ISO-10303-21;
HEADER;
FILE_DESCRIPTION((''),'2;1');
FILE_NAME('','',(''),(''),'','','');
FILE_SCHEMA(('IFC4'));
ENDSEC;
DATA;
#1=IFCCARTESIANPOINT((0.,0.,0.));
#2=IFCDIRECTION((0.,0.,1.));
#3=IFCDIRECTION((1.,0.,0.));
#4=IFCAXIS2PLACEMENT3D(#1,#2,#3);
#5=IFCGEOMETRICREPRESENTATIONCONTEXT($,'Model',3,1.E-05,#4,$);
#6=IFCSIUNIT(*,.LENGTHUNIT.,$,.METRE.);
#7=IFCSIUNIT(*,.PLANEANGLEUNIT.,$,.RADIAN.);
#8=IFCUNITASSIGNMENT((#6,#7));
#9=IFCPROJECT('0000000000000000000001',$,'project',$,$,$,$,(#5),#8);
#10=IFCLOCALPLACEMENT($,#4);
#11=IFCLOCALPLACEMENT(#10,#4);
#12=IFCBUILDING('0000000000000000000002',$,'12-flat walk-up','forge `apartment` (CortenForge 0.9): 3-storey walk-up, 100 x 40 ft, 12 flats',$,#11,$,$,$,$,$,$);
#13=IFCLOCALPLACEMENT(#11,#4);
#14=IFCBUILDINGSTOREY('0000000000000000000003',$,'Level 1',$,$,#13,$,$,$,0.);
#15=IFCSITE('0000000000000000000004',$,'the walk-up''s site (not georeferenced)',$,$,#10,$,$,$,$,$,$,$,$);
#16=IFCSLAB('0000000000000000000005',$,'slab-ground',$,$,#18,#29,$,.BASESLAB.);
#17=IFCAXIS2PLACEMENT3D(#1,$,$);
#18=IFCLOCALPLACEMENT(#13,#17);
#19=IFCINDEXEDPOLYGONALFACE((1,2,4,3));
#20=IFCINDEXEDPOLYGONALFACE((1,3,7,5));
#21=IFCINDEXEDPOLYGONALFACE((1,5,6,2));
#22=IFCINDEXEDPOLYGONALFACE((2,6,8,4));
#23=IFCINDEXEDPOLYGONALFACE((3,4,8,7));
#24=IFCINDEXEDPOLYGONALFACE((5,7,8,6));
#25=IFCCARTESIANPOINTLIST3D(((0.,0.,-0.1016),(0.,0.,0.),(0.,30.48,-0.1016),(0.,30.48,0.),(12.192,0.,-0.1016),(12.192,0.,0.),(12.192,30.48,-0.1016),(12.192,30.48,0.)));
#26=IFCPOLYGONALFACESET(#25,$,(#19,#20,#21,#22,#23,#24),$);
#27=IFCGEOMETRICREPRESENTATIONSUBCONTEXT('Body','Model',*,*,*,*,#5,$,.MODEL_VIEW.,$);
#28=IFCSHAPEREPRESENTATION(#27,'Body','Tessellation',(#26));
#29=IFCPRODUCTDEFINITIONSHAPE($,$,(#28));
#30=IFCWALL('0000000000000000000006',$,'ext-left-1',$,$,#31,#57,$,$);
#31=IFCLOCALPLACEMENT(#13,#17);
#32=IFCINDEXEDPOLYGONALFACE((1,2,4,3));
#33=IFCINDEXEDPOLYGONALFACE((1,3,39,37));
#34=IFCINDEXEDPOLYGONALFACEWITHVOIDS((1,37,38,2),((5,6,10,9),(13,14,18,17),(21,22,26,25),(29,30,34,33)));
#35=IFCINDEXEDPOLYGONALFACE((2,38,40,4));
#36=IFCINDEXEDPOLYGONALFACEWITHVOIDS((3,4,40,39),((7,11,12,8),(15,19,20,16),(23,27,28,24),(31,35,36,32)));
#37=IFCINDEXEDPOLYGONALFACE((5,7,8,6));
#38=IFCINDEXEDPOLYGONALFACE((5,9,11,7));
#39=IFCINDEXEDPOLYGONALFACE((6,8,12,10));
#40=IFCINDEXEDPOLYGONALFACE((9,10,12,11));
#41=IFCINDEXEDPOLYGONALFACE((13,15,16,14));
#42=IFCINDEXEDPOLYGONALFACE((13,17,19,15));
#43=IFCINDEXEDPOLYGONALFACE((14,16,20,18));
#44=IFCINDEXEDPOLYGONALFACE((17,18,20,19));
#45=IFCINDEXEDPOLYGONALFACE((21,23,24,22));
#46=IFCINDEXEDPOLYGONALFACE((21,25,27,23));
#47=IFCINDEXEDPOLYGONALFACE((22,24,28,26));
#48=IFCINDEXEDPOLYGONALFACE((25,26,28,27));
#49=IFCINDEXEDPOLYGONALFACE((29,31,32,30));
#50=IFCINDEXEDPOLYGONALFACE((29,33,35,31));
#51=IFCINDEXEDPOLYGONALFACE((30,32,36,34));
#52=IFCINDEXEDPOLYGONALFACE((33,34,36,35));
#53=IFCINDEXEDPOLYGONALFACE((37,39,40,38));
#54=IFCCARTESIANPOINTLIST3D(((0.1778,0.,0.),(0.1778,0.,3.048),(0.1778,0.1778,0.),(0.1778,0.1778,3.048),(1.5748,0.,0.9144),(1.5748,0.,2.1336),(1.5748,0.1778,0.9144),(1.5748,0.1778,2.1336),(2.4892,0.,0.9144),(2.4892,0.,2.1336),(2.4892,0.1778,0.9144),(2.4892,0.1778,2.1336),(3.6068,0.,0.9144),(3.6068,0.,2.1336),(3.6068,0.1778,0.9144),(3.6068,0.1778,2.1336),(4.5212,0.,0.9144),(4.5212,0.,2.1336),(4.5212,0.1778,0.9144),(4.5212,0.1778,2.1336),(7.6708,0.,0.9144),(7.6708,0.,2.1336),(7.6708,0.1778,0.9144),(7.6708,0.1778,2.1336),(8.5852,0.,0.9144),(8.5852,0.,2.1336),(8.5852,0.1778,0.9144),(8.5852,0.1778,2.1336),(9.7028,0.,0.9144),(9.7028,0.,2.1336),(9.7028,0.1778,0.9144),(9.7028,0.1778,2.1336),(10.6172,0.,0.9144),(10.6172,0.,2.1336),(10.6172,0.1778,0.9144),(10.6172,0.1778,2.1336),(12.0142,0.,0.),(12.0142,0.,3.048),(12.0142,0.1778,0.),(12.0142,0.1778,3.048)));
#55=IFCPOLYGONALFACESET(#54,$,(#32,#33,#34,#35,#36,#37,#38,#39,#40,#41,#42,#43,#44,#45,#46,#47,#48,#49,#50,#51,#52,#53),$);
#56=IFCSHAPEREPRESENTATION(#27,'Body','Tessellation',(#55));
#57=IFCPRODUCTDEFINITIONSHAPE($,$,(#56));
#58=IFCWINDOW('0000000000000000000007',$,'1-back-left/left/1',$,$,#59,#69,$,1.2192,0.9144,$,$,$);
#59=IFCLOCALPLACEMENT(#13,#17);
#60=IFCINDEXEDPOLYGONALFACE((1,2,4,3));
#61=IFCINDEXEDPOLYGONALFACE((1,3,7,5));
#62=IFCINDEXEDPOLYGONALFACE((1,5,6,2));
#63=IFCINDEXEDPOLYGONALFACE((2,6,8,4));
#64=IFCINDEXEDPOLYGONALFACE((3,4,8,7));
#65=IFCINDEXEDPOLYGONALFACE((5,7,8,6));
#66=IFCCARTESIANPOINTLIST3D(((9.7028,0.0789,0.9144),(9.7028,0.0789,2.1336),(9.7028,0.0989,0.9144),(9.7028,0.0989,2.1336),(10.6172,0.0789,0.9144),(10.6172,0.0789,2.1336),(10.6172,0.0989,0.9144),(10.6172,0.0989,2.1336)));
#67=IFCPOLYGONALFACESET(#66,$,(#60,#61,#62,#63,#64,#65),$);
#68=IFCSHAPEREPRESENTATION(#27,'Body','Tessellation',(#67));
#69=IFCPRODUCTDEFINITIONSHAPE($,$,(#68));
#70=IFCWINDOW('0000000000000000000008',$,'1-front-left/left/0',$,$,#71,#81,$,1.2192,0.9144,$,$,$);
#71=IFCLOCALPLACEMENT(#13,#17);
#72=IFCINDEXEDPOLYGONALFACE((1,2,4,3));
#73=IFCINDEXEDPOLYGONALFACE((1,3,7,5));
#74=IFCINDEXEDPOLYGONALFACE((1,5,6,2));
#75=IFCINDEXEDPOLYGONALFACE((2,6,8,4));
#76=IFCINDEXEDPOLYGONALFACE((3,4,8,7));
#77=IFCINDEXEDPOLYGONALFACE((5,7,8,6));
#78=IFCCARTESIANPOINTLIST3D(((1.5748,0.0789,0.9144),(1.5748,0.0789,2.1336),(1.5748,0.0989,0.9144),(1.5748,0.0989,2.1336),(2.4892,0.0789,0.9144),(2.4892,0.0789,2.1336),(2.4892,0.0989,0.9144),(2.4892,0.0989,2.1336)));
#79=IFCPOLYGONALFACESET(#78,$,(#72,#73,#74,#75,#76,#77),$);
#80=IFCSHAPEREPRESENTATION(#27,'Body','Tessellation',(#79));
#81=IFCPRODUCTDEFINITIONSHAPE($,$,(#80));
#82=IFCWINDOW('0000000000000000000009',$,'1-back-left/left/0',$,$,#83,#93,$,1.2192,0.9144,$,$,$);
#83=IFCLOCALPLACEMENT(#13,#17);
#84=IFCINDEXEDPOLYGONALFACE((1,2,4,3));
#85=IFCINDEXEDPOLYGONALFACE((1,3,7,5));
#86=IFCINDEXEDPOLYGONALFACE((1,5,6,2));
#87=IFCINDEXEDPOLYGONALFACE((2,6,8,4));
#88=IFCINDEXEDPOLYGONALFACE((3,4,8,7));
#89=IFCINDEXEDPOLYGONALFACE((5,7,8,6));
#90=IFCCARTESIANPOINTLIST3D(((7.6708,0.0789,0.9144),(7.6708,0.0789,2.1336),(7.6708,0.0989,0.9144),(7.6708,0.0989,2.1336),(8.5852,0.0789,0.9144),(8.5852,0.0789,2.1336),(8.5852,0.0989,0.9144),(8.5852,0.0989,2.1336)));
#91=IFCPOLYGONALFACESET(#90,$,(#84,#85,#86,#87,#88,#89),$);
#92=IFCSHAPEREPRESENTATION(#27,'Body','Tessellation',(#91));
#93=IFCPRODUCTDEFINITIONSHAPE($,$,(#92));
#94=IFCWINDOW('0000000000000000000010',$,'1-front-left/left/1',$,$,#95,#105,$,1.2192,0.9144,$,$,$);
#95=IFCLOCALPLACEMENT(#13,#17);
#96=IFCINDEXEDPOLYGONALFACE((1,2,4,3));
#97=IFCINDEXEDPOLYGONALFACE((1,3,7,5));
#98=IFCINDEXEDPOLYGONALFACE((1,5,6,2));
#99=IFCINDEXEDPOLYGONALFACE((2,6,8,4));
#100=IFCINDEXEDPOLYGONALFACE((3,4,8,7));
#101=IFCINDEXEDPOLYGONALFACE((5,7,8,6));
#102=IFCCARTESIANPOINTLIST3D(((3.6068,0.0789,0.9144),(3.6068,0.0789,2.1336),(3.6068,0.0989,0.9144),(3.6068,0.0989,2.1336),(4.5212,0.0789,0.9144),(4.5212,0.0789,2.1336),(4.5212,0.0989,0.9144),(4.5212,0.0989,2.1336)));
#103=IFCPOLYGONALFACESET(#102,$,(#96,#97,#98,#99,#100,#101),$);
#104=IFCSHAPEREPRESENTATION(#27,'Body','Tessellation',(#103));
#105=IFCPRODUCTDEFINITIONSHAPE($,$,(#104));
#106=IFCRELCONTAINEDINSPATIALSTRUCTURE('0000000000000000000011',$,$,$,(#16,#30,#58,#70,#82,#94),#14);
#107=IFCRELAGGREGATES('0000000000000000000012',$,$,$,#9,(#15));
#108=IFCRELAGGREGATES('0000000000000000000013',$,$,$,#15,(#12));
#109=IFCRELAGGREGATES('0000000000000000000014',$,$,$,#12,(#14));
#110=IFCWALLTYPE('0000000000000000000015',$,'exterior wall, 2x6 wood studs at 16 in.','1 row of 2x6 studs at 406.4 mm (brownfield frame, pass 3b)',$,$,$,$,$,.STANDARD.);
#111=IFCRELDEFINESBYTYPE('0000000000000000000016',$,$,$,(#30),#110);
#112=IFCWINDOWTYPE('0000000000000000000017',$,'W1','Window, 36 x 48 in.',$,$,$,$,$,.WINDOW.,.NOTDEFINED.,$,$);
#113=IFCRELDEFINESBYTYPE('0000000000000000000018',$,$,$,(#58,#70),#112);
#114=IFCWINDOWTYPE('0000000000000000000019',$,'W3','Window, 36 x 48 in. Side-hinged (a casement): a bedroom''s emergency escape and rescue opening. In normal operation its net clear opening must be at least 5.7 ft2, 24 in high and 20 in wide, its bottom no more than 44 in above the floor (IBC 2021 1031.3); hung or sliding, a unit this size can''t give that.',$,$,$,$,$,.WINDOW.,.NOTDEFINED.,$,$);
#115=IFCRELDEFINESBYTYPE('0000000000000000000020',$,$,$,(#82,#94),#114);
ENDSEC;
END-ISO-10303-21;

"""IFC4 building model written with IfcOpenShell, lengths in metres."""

from ifc_helpers import new_model, si_unit, frame, frame_2d, origin, origin_with_axes, place, context, subcontext, project, spatial, rectangle, extrude, type_object, element, fill, save


model = new_model("IFC4")

# Units and contexts
model_context = context("Model", 3, precision=1e-05, world=origin_with_axes())
body_context = subcontext(model_context, "Body", "Model", "MODEL_VIEW")
ifc_project = project(units=[si_unit("LENGTHUNIT", "METRE"), si_unit("PLANEANGLEUNIT", "RADIAN")], contexts=[model_context])

# Site, building, storey
site_placement = place(None, origin_with_axes())
site = spatial("IfcSite", under=ifc_project, at=site_placement, Name="the walk-up's site (not georeferenced)")
building_placement = place(site_placement, origin_with_axes())
building = spatial("IfcBuilding", under=site, at=building_placement, Name="12-flat walk-up", Description="forge `apartment` (CortenForge 0.9): 3-storey walk-up, 100 x 40 ft, 12 flats")
storey_placement = place(building_placement, origin_with_axes())
storey = spatial("IfcBuildingStorey", under=building, at=storey_placement, Name="Level 1", Elevation=0.0)

# Slab
slab_placement = place(storey_placement, frame((0.0, 0.0, -0.1016), z_axis=(0.0, 0.0, 1.0), x_axis=(1.0, 0.0, 0.0)))
element("IfcSlab", 1, at=slab_placement, inside=storey, Name="slab-ground", PredefinedType="BASESLAB", context=body_context, shape_type="SweptSolid", body=[
    extrude(rectangle(XDim=12.192, YDim=30.48, at=frame_2d((6.096, 15.24))), origin(), (0.0, 0.0, 1.0), 0.1016),
])

# Wall, openings, windows
wall_type = type_object("IfcWallType", Name="exterior wall, 2x6 wood studs at 16 in.", Description="1 row of 2x6 studs at 406.4 mm (brownfield frame, pass 3b)", PredefinedType="STANDARD")
wall_placement = place(storey_placement, frame((0.1778, 0.0, 0.0), z_axis=(0.0, 0.0, 1.0), x_axis=(1.0, 0.0, 0.0)))
wall = element("IfcWall", 2, at=wall_placement, inside=storey, type_object=wall_type, Name="ext-left-1", context=body_context, shape_type="SweptSolid", body=[
    extrude(rectangle(XDim=11.8364, YDim=0.1778, at=frame_2d((5.9182, 0.0889))), origin(), (0.0, 0.0, 1.0), 3.048),
])
opening_1_placement = place(wall_placement, frame((7.493, 0.0, 0.9144), z_axis=(0.0, 0.0, 1.0), x_axis=(1.0, 0.0, 0.0)))
opening_1 = element("IfcOpeningElement", 3, at=opening_1_placement, cuts=wall, PredefinedType="OPENING", context=body_context, shape_type="SweptSolid", body=[
    extrude(rectangle(XDim=0.9144, YDim=0.1778, at=frame_2d((0.4572, 0.0889))), origin(), (0.0, 0.0, 1.0), 1.2192),
])
opening_2_placement = place(wall_placement, frame((9.525, 0.0, 0.9144), z_axis=(0.0, 0.0, 1.0), x_axis=(1.0, 0.0, 0.0)))
opening_2 = element("IfcOpeningElement", 4, at=opening_2_placement, cuts=wall, PredefinedType="OPENING", context=body_context, shape_type="SweptSolid", body=[
    extrude(rectangle(XDim=0.9144, YDim=0.1778, at=frame_2d((0.4572, 0.0889))), origin(), (0.0, 0.0, 1.0), 1.2192),
])
opening_3_placement = place(wall_placement, frame((1.397, 0.0, 0.9144), z_axis=(0.0, 0.0, 1.0), x_axis=(1.0, 0.0, 0.0)))
opening_3 = element("IfcOpeningElement", 5, at=opening_3_placement, cuts=wall, PredefinedType="OPENING", context=body_context, shape_type="SweptSolid", body=[
    extrude(rectangle(XDim=0.9144, YDim=0.1778, at=frame_2d((0.4572, 0.0889))), origin(), (0.0, 0.0, 1.0), 1.2192),
])
opening_4_placement = place(wall_placement, frame((3.429, 0.0, 0.9144), z_axis=(0.0, 0.0, 1.0), x_axis=(1.0, 0.0, 0.0)))
opening_4 = element("IfcOpeningElement", 6, at=opening_4_placement, cuts=wall, PredefinedType="OPENING", context=body_context, shape_type="SweptSolid", body=[
    extrude(rectangle(XDim=0.9144, YDim=0.1778, at=frame_2d((0.4572, 0.0889))), origin(), (0.0, 0.0, 1.0), 1.2192),
])
window_type_1 = type_object("IfcWindowType", Name="W1", Description="Window, 36 x 48 in.", PartitioningType="NOTDEFINED", PredefinedType="WINDOW")
window_1_placement = place(opening_2_placement, frame((0.0, 0.0789, 0.0), z_axis=(0.0, 0.0, 1.0), x_axis=(1.0, 0.0, 0.0)))
window_1 = element("IfcWindow", 7, at=window_1_placement, inside=storey, type_object=window_type_1, Name="1-back-left/left/1", OverallHeight=1.2192, OverallWidth=0.9144, context=body_context, shape_type="SweptSolid", body=[
    extrude(rectangle(XDim=0.9144, YDim=0.02, at=frame_2d((0.4572, 0.01))), origin(), (0.0, 0.0, 1.0), 1.2192),
])
fill(opening_2, window_1)
window_2_placement = place(opening_3_placement, frame((0.0, 0.0789, 0.0), z_axis=(0.0, 0.0, 1.0), x_axis=(1.0, 0.0, 0.0)))
window_2 = element("IfcWindow", 8, at=window_2_placement, inside=storey, type_object=window_type_1, Name="1-front-left/left/0", OverallHeight=1.2192, OverallWidth=0.9144, context=body_context, shape_type="SweptSolid", body=[
    extrude(rectangle(XDim=0.9144, YDim=0.02, at=frame_2d((0.4572, 0.01))), origin(), (0.0, 0.0, 1.0), 1.2192),
])
fill(opening_3, window_2)
window_type_2 = type_object("IfcWindowType", Name="W3", Description="Window, 36 x 48 in. Side-hinged (a casement): a bedroom's emergency escape and rescue opening. In normal operation its net clear opening must be at least 5.7 ft2, 24 in high and 20 in wide, its bottom no more than 44 in above the floor (IBC 2021 1031.3); hung or sliding, a unit this size can't give that.", PartitioningType="NOTDEFINED", PredefinedType="WINDOW")
window_3_placement = place(opening_1_placement, frame((0.0, 0.0789, 0.0), z_axis=(0.0, 0.0, 1.0), x_axis=(1.0, 0.0, 0.0)))
window_3 = element("IfcWindow", 9, at=window_3_placement, inside=storey, type_object=window_type_2, Name="1-back-left/left/0", OverallHeight=1.2192, OverallWidth=0.9144, context=body_context, shape_type="SweptSolid", body=[
    extrude(rectangle(XDim=0.9144, YDim=0.02, at=frame_2d((0.4572, 0.01))), origin(), (0.0, 0.0, 1.0), 1.2192),
])
fill(opening_1, window_3)
window_4_placement = place(opening_4_placement, frame((0.0, 0.0789, 0.0), z_axis=(0.0, 0.0, 1.0), x_axis=(1.0, 0.0, 0.0)))
window_4 = element("IfcWindow", 10, at=window_4_placement, inside=storey, type_object=window_type_2, Name="1-front-left/left/1", OverallHeight=1.2192, OverallWidth=0.9144, context=body_context, shape_type="SweptSolid", body=[
    extrude(rectangle(XDim=0.9144, YDim=0.02, at=frame_2d((0.4572, 0.01))), origin(), (0.0, 0.0, 1.0), 1.2192),
])
fill(opening_4, window_4)

save(model, "model.ifc")
